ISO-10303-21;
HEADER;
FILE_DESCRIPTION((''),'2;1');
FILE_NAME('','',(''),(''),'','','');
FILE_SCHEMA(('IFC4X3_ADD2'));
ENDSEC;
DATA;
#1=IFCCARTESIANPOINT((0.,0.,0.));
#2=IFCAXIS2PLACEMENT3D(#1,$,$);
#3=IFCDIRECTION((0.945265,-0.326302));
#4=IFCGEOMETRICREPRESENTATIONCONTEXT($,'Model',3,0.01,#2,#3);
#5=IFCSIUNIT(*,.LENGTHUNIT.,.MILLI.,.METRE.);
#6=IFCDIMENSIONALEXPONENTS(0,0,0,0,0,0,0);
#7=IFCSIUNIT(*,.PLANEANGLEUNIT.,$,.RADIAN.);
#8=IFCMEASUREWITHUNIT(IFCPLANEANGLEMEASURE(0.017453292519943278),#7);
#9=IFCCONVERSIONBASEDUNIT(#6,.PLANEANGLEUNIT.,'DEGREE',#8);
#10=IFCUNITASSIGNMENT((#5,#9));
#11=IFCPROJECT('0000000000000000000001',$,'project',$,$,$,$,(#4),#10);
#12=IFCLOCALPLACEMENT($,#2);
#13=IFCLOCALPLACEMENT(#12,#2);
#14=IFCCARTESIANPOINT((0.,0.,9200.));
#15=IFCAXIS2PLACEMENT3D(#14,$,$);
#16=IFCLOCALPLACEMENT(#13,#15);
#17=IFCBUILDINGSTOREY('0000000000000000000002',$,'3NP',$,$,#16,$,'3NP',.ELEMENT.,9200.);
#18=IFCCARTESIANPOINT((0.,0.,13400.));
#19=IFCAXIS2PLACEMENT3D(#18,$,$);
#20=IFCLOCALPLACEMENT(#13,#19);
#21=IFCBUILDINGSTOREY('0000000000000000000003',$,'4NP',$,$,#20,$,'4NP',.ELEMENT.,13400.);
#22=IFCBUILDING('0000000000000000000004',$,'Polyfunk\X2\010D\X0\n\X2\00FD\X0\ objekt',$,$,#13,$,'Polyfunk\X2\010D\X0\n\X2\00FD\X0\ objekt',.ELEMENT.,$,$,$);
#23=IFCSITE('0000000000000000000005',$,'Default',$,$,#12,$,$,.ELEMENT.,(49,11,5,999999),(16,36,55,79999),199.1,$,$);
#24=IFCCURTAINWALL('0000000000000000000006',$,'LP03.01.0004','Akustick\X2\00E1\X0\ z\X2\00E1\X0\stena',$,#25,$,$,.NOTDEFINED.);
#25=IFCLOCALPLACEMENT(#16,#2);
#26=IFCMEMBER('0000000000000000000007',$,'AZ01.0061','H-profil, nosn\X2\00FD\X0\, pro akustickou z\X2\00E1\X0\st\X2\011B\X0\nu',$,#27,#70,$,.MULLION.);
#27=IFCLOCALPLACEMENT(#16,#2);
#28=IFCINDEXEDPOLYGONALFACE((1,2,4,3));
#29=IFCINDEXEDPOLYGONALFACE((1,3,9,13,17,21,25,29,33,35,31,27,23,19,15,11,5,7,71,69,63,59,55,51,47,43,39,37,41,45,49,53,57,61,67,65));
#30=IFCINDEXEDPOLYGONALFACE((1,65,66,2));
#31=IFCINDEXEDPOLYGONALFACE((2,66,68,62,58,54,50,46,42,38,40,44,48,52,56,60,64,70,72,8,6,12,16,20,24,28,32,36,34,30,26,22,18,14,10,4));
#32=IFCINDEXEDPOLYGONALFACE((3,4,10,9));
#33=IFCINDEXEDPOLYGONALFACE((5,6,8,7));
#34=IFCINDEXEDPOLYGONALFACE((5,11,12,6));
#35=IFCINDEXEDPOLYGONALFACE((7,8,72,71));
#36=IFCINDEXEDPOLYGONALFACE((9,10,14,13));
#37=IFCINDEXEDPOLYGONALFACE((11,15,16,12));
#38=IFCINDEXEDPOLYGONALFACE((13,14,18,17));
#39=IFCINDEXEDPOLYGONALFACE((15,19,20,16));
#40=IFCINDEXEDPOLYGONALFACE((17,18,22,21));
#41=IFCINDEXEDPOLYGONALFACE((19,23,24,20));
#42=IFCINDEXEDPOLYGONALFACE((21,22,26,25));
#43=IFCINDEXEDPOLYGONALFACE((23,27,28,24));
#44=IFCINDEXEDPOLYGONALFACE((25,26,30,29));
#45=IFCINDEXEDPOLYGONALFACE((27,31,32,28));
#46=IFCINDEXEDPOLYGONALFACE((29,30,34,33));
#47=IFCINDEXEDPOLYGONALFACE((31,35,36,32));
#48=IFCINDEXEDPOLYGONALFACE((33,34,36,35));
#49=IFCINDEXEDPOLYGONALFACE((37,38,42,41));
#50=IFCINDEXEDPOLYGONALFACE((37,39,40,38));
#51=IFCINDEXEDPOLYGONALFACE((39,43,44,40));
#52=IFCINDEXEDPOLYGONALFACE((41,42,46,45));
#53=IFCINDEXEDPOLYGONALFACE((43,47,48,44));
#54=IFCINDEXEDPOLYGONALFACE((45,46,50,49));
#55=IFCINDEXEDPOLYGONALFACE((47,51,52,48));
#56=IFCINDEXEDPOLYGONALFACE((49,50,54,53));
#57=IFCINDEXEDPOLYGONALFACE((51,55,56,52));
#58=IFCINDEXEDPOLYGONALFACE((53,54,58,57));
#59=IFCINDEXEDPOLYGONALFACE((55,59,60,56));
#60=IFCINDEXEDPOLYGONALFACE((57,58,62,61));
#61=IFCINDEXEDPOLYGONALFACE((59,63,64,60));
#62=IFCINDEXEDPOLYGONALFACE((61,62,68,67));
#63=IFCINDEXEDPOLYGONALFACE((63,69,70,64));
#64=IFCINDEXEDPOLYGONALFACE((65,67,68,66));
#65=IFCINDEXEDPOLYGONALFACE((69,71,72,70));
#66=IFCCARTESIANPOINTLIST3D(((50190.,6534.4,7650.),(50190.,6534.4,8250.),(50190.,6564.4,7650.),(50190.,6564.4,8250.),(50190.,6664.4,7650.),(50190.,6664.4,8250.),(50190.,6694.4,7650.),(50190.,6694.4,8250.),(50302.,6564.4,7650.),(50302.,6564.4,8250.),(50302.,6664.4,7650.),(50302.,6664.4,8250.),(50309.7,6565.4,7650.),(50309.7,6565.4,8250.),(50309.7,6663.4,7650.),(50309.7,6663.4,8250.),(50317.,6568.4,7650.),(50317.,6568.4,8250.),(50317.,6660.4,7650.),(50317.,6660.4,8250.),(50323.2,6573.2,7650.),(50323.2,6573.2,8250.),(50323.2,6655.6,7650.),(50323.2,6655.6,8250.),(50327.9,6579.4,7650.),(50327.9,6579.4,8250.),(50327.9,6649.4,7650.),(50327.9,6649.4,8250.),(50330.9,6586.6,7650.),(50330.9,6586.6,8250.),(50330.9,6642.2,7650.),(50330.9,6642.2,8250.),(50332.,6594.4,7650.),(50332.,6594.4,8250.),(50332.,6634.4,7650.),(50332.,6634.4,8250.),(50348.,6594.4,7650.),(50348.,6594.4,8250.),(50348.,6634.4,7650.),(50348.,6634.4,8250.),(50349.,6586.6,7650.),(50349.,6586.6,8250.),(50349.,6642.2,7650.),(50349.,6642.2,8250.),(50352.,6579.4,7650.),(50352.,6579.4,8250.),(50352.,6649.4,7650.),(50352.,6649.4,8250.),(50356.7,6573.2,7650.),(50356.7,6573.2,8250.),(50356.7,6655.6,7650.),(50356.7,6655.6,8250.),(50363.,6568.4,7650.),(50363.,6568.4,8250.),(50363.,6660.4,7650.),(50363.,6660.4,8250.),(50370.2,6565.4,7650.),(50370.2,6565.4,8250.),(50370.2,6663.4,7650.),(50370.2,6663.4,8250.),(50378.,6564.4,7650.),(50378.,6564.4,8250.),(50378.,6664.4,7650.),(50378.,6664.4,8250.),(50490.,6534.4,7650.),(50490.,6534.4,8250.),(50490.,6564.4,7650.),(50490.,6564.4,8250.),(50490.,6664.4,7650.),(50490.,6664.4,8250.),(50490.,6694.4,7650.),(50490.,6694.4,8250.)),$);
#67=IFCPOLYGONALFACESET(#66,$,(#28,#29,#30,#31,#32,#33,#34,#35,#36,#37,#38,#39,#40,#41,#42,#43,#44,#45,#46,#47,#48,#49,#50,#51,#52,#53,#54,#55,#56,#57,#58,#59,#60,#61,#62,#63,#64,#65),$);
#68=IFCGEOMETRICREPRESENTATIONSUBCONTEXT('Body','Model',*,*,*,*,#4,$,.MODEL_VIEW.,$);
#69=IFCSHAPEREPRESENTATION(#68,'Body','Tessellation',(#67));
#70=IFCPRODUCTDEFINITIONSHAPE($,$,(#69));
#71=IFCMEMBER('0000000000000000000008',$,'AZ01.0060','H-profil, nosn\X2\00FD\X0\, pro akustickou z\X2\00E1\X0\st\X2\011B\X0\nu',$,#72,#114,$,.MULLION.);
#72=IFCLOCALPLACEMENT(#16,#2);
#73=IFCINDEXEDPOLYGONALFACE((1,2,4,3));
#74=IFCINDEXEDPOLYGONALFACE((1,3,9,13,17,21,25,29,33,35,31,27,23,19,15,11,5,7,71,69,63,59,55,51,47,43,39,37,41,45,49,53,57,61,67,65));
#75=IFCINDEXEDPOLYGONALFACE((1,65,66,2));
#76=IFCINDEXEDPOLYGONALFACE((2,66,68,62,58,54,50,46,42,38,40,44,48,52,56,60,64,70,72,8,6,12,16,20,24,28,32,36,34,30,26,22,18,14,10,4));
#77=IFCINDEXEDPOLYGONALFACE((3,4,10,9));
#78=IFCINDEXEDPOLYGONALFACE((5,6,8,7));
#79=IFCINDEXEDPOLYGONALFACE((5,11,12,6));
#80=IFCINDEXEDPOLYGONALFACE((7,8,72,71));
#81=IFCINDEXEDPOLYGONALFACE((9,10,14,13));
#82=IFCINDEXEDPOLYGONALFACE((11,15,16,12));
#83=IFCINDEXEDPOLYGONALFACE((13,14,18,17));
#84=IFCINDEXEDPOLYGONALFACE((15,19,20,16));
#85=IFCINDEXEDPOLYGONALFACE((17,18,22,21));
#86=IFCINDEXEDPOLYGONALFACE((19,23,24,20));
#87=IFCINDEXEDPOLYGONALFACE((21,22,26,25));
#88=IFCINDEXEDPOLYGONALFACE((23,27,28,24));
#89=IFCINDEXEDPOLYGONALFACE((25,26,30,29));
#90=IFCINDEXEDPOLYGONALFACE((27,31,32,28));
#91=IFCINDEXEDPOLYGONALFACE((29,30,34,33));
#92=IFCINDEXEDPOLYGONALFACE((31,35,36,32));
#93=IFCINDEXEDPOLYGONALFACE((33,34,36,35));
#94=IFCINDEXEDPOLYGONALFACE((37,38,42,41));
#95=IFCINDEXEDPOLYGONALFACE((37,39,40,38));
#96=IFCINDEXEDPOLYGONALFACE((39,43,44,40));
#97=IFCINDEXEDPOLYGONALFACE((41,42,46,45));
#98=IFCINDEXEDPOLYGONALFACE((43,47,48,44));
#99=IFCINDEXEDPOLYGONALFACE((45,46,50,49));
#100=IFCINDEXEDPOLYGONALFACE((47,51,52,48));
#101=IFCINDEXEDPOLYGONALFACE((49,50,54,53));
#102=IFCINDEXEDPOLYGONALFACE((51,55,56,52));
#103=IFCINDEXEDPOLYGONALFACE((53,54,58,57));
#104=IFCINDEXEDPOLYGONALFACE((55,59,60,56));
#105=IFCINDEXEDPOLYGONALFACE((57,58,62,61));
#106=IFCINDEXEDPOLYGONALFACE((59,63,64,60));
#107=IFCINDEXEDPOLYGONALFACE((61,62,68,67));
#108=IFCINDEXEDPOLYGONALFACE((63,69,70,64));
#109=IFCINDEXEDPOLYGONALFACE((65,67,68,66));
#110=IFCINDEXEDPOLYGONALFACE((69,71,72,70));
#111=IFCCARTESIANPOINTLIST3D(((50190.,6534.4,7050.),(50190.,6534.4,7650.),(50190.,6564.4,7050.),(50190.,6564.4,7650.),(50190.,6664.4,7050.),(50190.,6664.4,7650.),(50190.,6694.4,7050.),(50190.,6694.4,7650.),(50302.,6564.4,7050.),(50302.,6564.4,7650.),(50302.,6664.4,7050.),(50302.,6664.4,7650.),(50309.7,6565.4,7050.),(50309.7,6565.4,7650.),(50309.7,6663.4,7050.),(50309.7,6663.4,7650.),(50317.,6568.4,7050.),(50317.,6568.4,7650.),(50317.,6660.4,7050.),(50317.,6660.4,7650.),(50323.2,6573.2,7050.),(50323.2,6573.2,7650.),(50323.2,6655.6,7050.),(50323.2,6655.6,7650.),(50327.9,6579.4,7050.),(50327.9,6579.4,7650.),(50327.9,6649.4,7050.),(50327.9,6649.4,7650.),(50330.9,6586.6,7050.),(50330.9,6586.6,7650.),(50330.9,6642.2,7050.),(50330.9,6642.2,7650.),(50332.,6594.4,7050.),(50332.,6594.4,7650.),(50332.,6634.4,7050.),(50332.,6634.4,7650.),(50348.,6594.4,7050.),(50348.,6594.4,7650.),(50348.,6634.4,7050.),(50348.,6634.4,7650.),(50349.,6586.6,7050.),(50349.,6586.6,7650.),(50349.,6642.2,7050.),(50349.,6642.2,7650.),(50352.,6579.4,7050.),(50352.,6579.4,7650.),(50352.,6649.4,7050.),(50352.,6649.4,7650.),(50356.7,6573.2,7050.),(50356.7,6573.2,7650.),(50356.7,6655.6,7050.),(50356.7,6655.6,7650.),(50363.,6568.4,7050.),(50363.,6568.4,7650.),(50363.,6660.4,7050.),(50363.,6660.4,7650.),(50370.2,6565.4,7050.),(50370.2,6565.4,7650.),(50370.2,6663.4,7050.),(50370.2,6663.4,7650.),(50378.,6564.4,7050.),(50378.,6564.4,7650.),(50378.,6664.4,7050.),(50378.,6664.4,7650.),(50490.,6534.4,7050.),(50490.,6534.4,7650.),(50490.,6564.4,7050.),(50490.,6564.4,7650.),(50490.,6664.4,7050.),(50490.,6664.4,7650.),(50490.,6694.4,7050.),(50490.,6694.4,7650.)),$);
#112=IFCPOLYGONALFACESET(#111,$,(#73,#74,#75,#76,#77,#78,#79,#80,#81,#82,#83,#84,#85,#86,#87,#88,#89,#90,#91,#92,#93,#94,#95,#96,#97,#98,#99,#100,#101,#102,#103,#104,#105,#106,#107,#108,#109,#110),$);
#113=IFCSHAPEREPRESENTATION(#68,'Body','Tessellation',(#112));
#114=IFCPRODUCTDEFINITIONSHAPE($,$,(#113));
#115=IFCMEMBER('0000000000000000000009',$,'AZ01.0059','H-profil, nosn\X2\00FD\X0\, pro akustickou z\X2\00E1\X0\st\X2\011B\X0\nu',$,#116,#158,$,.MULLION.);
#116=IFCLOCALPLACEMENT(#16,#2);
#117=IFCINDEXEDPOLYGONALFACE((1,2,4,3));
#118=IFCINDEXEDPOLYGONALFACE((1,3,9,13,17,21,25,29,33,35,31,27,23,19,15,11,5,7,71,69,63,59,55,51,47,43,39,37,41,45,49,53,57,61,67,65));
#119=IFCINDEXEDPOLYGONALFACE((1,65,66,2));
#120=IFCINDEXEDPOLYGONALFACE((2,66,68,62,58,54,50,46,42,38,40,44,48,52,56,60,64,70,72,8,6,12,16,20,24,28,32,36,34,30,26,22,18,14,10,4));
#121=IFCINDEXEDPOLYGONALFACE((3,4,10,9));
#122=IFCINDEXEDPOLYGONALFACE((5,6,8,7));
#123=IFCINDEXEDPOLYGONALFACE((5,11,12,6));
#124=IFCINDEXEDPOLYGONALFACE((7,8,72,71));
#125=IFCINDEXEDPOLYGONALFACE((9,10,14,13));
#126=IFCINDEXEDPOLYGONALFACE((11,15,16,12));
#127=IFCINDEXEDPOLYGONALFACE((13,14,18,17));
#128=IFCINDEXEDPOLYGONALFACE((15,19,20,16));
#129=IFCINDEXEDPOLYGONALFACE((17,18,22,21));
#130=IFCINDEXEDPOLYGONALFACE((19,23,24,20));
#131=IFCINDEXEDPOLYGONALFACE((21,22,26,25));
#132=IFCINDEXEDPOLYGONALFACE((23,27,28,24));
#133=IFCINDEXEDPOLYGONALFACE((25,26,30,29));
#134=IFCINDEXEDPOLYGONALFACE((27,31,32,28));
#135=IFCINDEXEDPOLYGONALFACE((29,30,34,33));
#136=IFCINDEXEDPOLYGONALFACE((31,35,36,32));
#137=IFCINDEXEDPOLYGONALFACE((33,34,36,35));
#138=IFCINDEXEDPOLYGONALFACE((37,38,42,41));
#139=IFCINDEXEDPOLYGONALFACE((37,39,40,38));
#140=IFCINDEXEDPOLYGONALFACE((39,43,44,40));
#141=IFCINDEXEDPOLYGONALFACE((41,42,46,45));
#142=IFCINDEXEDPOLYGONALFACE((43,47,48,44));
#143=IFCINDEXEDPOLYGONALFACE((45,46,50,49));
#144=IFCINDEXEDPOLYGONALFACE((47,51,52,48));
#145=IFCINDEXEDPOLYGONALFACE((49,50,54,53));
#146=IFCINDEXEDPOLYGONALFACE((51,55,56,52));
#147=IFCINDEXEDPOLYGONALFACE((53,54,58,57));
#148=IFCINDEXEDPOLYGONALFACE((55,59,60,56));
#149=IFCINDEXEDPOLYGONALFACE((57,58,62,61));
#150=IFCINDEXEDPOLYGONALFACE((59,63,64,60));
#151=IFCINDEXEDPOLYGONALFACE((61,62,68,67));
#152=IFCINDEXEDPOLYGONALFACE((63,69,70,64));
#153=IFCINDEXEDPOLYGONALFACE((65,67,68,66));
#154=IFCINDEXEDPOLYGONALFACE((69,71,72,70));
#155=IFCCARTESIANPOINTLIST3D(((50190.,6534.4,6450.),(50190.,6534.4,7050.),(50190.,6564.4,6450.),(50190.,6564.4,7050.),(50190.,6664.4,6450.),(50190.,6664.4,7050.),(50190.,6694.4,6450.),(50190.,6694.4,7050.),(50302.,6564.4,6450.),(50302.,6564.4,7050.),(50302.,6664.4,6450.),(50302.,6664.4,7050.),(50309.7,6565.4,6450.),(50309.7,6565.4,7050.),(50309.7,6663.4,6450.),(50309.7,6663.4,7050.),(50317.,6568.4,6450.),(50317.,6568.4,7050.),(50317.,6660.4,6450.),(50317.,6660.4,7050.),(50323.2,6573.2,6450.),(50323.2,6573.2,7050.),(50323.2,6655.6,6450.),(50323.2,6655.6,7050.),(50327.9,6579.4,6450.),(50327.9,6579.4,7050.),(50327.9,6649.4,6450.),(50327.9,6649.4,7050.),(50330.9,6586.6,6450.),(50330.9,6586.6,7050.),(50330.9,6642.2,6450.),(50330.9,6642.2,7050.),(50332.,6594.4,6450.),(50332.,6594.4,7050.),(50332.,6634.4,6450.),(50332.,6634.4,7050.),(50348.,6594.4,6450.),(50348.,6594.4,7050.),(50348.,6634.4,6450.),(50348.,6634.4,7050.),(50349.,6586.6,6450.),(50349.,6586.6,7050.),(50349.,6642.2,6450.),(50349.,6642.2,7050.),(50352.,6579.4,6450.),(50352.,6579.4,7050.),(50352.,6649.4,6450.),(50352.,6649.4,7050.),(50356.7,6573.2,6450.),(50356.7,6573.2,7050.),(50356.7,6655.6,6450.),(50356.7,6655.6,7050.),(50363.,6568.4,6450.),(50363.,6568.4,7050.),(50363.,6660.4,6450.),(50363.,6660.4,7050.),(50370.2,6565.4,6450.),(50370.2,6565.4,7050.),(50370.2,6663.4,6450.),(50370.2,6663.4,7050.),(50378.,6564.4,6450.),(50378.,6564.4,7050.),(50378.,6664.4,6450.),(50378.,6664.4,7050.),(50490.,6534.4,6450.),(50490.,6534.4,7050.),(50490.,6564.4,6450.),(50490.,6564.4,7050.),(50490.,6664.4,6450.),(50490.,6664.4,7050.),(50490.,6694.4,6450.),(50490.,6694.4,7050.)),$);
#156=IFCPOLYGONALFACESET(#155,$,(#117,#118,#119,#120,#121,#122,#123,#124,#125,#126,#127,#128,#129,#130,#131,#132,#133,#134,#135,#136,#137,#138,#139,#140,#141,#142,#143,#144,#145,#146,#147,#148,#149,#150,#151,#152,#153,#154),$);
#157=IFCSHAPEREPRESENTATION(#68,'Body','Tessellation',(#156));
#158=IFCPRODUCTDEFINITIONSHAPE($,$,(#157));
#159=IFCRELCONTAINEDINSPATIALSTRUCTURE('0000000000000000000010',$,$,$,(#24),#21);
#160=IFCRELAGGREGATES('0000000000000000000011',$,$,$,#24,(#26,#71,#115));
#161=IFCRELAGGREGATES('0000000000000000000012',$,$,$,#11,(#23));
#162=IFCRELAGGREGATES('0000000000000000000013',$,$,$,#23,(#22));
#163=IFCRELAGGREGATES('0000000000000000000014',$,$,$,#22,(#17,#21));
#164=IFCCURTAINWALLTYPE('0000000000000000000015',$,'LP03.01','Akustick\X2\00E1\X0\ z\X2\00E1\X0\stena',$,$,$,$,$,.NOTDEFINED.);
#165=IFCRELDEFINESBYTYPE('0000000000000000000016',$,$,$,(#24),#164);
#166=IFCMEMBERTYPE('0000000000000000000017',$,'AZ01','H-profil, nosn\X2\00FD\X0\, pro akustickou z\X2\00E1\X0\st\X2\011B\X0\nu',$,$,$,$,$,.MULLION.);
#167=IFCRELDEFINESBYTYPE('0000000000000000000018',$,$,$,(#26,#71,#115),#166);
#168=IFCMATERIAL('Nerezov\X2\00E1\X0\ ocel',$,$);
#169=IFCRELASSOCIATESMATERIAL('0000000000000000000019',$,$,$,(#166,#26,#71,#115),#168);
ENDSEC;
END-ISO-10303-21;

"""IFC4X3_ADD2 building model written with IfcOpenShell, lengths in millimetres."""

from ifc_helpers import new_model, entity, si_unit, converted_unit, direction, frame, frame_2d, origin, place, context, subcontext, project, spatial, polyline, circle_curve, parameter, trimmed, segment, composite_curve, outline, extrude, source, transform, mapped, material, material_profile, profile_set, profile_usage, type_object, element, aggregate, save


model = new_model("IFC4X3_ADD2")

# Units and contexts
model_context = context("Model", 3, precision=0.01, world=origin(), true_north=direction((0.945265, -0.326302)))
body_context = subcontext(model_context, "Body", "Model", "MODEL_VIEW")
ifc_project = project(units=[si_unit("LENGTHUNIT", "METRE", prefix="MILLI"), converted_unit("PLANEANGLEUNIT", "DEGREE", entity("IfcPlaneAngleMeasure", 0.017453292519943278), si_unit("PLANEANGLEUNIT", "RADIAN"), dimensions=[0, 0, 0, 0, 0, 0, 0])], contexts=[model_context])

# Site, building, storey
site_placement = place(None, origin())
site = spatial("IfcSite", under=ifc_project, at=site_placement, Name="Default", CompositionType="ELEMENT", RefLatitude=(49, 11, 5, 999999), RefLongitude=(16, 36, 55, 79999), RefElevation=199.1)
building_placement = place(site_placement, origin())
building = spatial("IfcBuilding", under=site, at=building_placement, Name="Polyfunkčný objekt", LongName="Polyfunkčný objekt", CompositionType="ELEMENT")
storey_1_placement = place(building_placement, frame((0.0, 0.0, 9200.0)))
storey_1 = spatial("IfcBuildingStorey", under=building, at=storey_1_placement, Name="3NP", LongName="3NP", CompositionType="ELEMENT", Elevation=9200.0)

# Shared definitions
storey_2_placement = place(building_placement, frame((0.0, 0.0, 13400.0)))
storey_2 = spatial("IfcBuildingStorey", under=building, at=storey_2_placement, Name="4NP", LongName="4NP", CompositionType="ELEMENT", Elevation=13400.0)

# Curtain wall, members
curtain_wall_type_1 = type_object("IfcCurtainWallType", Name="LP03.01", Description="Akustická zástena", PredefinedType="NOTDEFINED")
curtain_wall_1_placement = place(storey_2_placement, frame((0.0, 0.0, -13400.0)))
curtain_wall_1 = element("IfcCurtainWall", 1, at=curtain_wall_1_placement, inside=storey_2, type_object=curtain_wall_type_1, Name="LP03.01.0004", Description="Akustická zástena", PredefinedType="NOTDEFINED")
ifc_material_1 = material(Name="Nerezová ocel")
ifc_material_profile_1 = material_profile(ifc_material_1, outline(composite_curve([segment(polyline([(50.0, -150.0), (80.0, -150.0)]), True, "CONTINUOUS"), segment(polyline([(80.0, -150.0), (80.0, 150.0)]), True, "CONTINUOUS"), segment(polyline([(80.0, 150.0), (50.0, 150.0)]), True, "CONTINUOUS"), segment(polyline([(50.0, 150.0), (50.0, 38.0)]), True, "CONTINUOUS"), segment(trimmed(circle_curve(frame_2d((20.0, 38.0), x_axis=(0.0, 1.0)), 30.0), [parameter(180.0)], [parameter(270.0)], True, "PARAMETER"), False, "CONTINUOUS"), segment(polyline([(20.0, 8.0), (-20.0, 8.0)]), True, "CONTINUOUS"), segment(trimmed(circle_curve(frame_2d((-20.0, 38.0), x_axis=(0.0, 1.0)), 30.0), [parameter(90.0)], [parameter(180.0)], True, "PARAMETER"), False, "CONTINUOUS"), segment(polyline([(-50.0, 38.0), (-50.0, 150.0)]), True, "CONTINUOUS"), segment(polyline([(-50.0, 150.0), (-80.0, 150.0)]), True, "CONTINUOUS"), segment(polyline([(-80.0, 150.0), (-80.0, -150.0)]), True, "CONTINUOUS"), segment(polyline([(-80.0, -150.0), (-50.0, -150.0)]), True, "CONTINUOUS"), segment(polyline([(-50.0, -150.0), (-50.0, -38.0)]), True, "CONTINUOUS"), segment(trimmed(circle_curve(frame_2d((-20.0, -38.0), x_axis=(0.0, 1.0)), 30.0), [parameter(0.0)], [parameter(90.0)], True, "PARAMETER"), False, "CONTINUOUS"), segment(polyline([(-20.0, -8.0), (20.0, -8.0)]), True, "CONTINUOUS"), segment(trimmed(circle_curve(frame_2d((20.0, -38.0), x_axis=(0.0, 1.0)), 30.0), [parameter(270.0)], [parameter(0.0)], True, "PARAMETER"), False, "CONTINUOUS"), segment(polyline([(50.0, -38.0), (50.0, -150.0)]), True, "CONTINUOUS")], self_intersect=False)), Name="Profil zástena")
ifc_profile_set_1 = profile_set([ifc_material_profile_1], Name="Profil zástena")
ifc_profile_usage_1 = profile_usage(ifc_profile_set_1)
member_type_1 = type_object("IfcMemberType", Name="AZ01", Description="H-profil, nosný, pro akustickou zástěnu", PredefinedType="MULLION", material=ifc_profile_set_1)
shared_shape_1 = source(origin(), body_context, "Body", "SweptSolid", [
    extrude(outline(composite_curve([segment(polyline([(-150.0, -50.0), (-150.0, -80.0)]), True, "CONTINUOUS"), segment(polyline([(-150.0, -80.0), (150.0, -80.0)]), True, "CONTINUOUS"), segment(polyline([(150.0, -80.0), (150.0, -50.0)]), True, "CONTINUOUS"), segment(polyline([(150.0, -50.0), (38.0, -50.0)]), True, "CONTINUOUS"), segment(trimmed(circle_curve(frame_2d((38.0, -20.0), x_axis=(1.0, 0.0)), 30.0), [parameter(180.0)], [parameter(270.0)], True, "PARAMETER"), False, "CONTINUOUS"), segment(polyline([(8.0, -20.0), (8.0, 20.0)]), True, "CONTINUOUS"), segment(trimmed(circle_curve(frame_2d((38.0, 20.0), x_axis=(1.0, 0.0)), 30.0), [parameter(90.0)], [parameter(180.0)], True, "PARAMETER"), False, "CONTINUOUS"), segment(polyline([(38.0, 50.0), (150.0, 50.0)]), True, "CONTINUOUS"), segment(polyline([(150.0, 50.0), (150.0, 80.0)]), True, "CONTINUOUS"), segment(polyline([(150.0, 80.0), (-150.0, 80.0)]), True, "CONTINUOUS"), segment(polyline([(-150.0, 80.0), (-150.0, 50.0)]), True, "CONTINUOUS"), segment(polyline([(-150.0, 50.0), (-38.0, 50.0)]), True, "CONTINUOUS"), segment(trimmed(circle_curve(frame_2d((-38.0, 20.0), x_axis=(1.0, 0.0)), 30.0), [parameter(0.0)], [parameter(90.0)], True, "PARAMETER"), False, "CONTINUOUS"), segment(polyline([(-8.0, 20.0), (-8.0, -20.0)]), True, "CONTINUOUS"), segment(trimmed(circle_curve(frame_2d((-38.0, -20.0), x_axis=(1.0, 0.0)), 30.0), [parameter(270.0)], [parameter(0.0)], True, "PARAMETER"), False, "CONTINUOUS"), segment(polyline([(-38.0, -50.0), (-150.0, -50.0)]), True, "CONTINUOUS")], self_intersect=False)), frame((-150.0, 0.0, -600.0), z_axis=(0.0, 0.0, -1.0), x_axis=(-1.0, 0.0, 0.0)), (0.0, 0.0, -1.0), 600.0),
])
member_1_placement = place(curtain_wall_1_placement, frame((50190.0, 6614.4, 17450.0), z_axis=(0.0, 0.0, 1.0), x_axis=(-1.0, 0.0, 0.0)))
member_1 = element("IfcMember", 2, at=member_1_placement, type_object=member_type_1, material=ifc_profile_usage_1, Name="AZ01.0061", Description="H-profil, nosný, pro akustickou zástěnu", PredefinedType="MULLION", context=body_context, shape_type="MappedRepresentation", body=[
    mapped(shared_shape_1, transform((0.0, 0.0, 0.0), scale=1.0)),
])
member_2_placement = place(curtain_wall_1_placement, frame((50190.0, 6614.4, 16850.0), z_axis=(0.0, 0.0, 1.0), x_axis=(-1.0, 0.0, 0.0)))
member_2 = element("IfcMember", 3, at=member_2_placement, type_object=member_type_1, material=ifc_profile_usage_1, Name="AZ01.0060", Description="H-profil, nosný, pro akustickou zástěnu", PredefinedType="MULLION", context=body_context, shape_type="MappedRepresentation", body=[
    mapped(shared_shape_1, transform((0.0, 0.0, 0.0), scale=1.0)),
])
member_3_placement = place(curtain_wall_1_placement, frame((50190.0, 6614.4, 16250.0), z_axis=(0.0, 0.0, 1.0), x_axis=(-1.0, 0.0, 0.0)))
member_3 = element("IfcMember", 4, at=member_3_placement, type_object=member_type_1, material=ifc_profile_usage_1, Name="AZ01.0059", Description="H-profil, nosný, pro akustickou zástěnu", PredefinedType="MULLION", context=body_context, shape_type="MappedRepresentation", body=[
    mapped(shared_shape_1, transform((0.0, 0.0, 0.0), scale=1.0)),
])

aggregate(curtain_wall_1, [member_1, member_2, member_3])

save(model, "model.ifc")
